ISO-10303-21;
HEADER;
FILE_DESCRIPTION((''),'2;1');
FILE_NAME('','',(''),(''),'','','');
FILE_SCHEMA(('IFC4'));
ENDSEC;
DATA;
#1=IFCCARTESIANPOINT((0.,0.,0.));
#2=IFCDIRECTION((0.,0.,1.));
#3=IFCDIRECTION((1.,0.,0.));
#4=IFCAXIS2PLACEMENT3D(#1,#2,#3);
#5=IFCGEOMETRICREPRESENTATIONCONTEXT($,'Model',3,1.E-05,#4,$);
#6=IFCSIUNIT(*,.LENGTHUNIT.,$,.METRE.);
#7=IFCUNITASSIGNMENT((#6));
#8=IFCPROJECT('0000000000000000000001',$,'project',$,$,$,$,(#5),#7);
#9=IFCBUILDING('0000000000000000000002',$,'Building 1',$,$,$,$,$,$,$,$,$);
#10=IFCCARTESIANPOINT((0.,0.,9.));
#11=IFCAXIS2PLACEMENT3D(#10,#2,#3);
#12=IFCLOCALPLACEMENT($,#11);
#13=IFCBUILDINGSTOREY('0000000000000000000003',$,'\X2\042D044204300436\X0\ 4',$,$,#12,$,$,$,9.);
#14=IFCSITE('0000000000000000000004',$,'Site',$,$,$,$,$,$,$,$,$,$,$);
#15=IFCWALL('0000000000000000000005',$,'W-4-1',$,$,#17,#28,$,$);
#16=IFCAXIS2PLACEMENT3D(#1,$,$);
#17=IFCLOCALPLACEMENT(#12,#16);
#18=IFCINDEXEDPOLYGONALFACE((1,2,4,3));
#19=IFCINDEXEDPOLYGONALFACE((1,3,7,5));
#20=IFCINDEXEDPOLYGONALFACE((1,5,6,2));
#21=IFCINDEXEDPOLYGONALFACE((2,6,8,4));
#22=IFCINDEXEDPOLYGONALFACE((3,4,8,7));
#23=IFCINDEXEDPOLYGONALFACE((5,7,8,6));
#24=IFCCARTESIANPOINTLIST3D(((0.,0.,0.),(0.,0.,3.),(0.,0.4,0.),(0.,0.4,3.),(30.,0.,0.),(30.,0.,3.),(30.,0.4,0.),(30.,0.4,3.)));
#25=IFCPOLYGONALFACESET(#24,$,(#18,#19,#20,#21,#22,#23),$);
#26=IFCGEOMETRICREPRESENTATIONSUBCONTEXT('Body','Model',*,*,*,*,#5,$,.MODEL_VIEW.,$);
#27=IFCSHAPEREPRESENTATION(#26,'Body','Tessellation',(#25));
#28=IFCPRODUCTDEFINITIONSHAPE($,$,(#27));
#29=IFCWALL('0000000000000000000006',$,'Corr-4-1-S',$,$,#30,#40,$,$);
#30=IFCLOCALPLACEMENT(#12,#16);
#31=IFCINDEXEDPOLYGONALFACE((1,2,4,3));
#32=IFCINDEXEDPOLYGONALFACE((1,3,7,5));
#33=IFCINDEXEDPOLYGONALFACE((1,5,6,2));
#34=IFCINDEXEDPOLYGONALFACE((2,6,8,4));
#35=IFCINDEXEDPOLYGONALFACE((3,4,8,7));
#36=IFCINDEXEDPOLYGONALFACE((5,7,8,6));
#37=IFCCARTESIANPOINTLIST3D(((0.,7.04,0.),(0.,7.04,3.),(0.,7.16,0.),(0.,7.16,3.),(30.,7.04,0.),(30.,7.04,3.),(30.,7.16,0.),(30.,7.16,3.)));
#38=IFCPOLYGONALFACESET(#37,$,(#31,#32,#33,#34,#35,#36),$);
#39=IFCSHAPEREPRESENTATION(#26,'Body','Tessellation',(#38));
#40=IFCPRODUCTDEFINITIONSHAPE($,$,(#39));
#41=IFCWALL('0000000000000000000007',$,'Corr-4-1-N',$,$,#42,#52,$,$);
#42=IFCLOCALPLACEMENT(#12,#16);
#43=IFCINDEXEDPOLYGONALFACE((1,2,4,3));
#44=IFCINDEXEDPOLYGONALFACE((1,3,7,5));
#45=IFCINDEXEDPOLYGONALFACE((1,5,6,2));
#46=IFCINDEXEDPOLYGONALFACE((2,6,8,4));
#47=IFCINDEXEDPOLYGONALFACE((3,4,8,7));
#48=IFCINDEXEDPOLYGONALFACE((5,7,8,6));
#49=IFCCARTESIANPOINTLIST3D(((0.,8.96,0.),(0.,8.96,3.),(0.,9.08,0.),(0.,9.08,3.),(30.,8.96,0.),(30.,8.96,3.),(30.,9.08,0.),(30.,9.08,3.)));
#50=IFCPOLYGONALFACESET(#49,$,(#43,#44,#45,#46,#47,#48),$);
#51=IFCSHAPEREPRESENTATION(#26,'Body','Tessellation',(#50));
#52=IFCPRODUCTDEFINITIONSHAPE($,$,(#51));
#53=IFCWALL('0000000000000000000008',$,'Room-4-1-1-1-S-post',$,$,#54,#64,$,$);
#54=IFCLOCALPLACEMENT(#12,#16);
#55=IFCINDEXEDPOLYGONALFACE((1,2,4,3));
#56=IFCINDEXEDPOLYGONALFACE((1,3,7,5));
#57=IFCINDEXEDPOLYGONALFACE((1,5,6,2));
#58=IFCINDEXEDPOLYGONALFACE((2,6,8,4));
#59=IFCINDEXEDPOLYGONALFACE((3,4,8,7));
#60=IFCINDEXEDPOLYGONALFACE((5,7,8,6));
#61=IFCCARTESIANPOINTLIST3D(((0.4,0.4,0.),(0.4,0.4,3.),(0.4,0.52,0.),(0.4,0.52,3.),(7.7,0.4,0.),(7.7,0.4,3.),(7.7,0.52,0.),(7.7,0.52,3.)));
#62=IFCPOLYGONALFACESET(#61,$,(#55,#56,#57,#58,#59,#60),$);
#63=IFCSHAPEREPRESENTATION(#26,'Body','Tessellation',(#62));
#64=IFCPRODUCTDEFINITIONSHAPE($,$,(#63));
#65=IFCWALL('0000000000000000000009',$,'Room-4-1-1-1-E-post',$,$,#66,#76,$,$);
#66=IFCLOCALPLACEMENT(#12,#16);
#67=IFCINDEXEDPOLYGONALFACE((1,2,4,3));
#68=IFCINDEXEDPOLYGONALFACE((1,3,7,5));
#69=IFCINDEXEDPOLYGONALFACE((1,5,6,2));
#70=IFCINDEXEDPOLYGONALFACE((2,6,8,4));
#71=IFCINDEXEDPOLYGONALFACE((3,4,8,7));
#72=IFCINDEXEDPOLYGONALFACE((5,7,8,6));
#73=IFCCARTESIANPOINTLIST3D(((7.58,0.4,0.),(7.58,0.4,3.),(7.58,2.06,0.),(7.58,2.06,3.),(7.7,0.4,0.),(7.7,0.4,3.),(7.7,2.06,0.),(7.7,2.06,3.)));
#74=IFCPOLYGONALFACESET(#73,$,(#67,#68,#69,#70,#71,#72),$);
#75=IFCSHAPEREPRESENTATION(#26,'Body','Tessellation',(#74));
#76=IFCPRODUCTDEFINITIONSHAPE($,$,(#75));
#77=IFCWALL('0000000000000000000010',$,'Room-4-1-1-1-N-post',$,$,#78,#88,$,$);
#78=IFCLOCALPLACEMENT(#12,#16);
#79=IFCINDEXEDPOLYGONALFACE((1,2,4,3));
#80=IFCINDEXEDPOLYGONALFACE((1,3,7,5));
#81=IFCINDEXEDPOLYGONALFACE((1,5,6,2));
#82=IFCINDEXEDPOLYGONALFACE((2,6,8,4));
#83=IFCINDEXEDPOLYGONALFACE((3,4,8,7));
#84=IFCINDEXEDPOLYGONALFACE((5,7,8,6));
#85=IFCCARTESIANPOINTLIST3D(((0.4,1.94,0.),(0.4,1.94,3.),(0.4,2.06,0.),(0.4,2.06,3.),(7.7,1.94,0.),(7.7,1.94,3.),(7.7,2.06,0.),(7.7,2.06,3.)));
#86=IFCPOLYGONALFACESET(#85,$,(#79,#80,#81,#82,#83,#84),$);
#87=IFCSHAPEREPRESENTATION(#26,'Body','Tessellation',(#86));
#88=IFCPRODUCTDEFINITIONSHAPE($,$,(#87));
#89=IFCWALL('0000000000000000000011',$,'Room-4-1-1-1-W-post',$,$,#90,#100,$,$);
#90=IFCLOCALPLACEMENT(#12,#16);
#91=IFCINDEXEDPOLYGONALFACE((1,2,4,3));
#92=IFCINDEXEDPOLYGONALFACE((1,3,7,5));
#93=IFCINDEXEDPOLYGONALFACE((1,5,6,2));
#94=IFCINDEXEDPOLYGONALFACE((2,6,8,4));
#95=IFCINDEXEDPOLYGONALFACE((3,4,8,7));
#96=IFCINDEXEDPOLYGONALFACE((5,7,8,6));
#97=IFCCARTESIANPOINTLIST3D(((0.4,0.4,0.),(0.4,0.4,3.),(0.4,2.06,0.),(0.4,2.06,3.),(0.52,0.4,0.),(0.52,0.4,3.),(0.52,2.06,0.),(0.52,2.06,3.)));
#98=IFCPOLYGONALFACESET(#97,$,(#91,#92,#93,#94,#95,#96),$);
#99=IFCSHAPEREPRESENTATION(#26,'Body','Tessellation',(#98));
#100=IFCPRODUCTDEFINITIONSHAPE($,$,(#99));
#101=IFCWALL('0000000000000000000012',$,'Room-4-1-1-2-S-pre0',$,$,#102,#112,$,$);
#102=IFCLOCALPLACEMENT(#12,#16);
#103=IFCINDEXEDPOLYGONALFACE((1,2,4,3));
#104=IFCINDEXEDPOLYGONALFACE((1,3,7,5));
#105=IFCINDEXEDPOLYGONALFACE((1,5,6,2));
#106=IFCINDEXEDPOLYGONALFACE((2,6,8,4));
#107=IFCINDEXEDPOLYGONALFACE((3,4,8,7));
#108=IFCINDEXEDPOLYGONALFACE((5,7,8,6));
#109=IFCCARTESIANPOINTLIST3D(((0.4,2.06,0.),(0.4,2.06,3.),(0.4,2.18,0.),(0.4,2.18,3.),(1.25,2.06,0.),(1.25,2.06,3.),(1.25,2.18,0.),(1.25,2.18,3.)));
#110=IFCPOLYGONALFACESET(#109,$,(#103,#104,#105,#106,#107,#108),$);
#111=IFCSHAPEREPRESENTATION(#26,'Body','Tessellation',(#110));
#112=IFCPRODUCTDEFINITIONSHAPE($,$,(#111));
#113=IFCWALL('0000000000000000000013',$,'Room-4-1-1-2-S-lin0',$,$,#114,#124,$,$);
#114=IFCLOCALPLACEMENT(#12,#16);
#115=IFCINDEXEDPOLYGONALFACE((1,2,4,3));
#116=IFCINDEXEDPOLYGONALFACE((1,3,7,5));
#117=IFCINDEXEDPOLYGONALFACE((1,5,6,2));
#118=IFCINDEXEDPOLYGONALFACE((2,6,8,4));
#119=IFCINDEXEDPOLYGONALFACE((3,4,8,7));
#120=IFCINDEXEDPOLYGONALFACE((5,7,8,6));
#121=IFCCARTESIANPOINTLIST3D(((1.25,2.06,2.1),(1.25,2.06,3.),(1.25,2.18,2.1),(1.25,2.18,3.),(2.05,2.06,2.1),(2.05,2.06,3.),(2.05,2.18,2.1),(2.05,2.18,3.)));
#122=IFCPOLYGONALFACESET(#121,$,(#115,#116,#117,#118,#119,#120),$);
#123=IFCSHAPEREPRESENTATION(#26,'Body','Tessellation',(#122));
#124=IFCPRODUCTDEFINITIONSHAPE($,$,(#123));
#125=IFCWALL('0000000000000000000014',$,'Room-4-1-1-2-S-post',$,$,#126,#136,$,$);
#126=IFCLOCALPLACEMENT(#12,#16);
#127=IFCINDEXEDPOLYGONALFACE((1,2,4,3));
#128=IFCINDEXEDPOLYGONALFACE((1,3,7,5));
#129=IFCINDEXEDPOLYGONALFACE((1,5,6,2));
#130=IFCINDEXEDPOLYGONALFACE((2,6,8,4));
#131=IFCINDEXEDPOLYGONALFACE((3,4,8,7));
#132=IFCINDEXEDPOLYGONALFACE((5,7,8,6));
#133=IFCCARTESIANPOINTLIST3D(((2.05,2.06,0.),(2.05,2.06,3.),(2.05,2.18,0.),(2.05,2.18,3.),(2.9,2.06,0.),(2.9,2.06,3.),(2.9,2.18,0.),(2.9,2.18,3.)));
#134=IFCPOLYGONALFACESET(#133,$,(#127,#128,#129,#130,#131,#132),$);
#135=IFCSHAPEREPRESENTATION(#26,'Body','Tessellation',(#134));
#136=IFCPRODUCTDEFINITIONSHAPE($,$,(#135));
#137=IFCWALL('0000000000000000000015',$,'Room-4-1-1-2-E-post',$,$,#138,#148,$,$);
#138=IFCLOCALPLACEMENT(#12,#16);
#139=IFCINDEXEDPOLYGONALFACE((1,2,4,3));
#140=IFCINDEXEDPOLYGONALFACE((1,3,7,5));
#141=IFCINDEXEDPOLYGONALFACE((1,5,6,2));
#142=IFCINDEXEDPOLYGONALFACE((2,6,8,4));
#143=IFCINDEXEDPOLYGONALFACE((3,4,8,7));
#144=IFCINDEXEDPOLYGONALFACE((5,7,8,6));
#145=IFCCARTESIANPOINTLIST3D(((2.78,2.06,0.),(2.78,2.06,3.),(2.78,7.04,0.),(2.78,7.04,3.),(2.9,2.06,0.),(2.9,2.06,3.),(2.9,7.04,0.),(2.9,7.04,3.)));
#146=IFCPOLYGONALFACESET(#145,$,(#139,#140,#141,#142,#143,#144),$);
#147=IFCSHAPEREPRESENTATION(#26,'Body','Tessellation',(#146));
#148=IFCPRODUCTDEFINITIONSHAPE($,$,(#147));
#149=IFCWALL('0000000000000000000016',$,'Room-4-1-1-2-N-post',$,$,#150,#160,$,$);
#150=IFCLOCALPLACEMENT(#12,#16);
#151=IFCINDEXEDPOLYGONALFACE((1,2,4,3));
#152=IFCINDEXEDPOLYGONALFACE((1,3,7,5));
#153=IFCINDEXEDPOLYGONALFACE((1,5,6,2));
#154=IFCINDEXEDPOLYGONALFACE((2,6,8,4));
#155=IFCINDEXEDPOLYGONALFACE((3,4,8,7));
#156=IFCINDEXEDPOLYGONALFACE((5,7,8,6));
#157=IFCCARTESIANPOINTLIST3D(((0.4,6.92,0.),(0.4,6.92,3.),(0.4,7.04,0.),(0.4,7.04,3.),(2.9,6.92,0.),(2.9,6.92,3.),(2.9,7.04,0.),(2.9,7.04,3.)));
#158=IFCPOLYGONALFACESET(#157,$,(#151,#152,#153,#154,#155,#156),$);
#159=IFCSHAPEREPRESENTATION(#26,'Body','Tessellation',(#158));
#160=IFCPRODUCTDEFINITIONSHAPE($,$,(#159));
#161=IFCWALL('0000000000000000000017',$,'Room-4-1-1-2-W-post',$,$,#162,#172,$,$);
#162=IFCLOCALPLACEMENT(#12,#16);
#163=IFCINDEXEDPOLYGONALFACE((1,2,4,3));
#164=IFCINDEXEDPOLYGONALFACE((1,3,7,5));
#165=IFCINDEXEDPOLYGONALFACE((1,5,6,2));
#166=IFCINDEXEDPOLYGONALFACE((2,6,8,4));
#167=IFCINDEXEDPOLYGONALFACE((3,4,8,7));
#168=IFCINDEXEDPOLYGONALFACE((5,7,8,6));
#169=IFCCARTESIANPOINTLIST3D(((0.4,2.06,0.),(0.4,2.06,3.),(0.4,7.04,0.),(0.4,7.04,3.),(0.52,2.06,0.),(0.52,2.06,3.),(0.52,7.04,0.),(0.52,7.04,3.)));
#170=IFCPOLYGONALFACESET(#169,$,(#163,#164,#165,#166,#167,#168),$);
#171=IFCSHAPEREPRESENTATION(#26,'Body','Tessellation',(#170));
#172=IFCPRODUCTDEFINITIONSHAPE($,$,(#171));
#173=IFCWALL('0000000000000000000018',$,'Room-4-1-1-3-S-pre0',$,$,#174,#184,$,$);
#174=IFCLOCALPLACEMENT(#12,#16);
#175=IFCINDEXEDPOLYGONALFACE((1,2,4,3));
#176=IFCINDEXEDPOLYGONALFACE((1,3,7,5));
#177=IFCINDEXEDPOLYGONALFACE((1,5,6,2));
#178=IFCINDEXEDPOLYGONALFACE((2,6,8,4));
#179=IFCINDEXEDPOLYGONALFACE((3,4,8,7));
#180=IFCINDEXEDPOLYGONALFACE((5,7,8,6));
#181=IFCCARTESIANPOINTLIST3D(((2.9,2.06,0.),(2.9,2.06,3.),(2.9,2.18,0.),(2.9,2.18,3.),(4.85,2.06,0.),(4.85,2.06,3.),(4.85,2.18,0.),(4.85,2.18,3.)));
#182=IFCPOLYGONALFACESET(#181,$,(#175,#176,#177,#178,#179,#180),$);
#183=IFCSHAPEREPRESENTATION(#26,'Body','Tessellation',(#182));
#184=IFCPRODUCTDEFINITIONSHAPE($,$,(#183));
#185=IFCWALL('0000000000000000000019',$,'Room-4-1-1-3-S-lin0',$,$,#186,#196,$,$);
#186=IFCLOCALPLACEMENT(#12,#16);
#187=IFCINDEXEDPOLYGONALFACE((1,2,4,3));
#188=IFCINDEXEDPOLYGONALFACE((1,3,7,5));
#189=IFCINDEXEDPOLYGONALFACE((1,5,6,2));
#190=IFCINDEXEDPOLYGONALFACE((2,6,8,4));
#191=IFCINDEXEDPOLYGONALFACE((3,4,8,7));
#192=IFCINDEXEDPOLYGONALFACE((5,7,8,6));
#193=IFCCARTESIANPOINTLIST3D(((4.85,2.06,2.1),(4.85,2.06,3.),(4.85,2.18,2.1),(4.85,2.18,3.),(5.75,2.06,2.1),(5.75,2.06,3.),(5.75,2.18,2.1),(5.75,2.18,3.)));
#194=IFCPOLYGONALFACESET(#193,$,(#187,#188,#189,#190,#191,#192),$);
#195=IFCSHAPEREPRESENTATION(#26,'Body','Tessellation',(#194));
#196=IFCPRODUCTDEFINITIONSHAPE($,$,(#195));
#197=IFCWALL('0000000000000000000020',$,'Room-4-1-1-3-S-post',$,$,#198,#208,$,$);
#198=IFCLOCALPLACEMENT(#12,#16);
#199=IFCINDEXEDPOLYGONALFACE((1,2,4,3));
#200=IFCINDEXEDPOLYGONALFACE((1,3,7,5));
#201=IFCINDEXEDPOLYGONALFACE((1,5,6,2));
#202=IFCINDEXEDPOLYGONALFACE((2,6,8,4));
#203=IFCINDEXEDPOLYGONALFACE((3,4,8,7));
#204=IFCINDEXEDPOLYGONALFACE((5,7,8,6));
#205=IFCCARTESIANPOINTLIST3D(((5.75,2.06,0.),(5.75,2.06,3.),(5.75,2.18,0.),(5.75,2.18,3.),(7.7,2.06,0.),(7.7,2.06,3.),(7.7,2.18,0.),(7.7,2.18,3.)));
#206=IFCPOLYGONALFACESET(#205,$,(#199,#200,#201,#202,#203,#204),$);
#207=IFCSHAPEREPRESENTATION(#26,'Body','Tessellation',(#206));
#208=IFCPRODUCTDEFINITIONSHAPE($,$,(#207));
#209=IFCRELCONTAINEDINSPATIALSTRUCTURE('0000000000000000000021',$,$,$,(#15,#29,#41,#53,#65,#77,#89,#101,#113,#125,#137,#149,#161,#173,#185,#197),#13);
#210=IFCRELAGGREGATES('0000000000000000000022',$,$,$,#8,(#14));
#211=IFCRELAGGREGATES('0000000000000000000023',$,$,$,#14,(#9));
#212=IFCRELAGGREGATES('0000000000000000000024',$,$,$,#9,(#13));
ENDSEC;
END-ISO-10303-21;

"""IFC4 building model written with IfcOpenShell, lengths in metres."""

from ifc_helpers import new_model, si_unit, frame, origin_with_axes, place, context, subcontext, project, spatial, indexed_curve, outline, extrude, element, save


model = new_model("IFC4")

# Units and contexts
model_context = context("Model", 3, precision=1e-05, world=origin_with_axes())
body_context = subcontext(model_context, "Body", "Model", "MODEL_VIEW")
ifc_project = project(units=[si_unit("LENGTHUNIT", "METRE")], contexts=[model_context])

# Site, building, storey
site = spatial("IfcSite", under=ifc_project, Name="Site")
building = spatial("IfcBuilding", under=site, Name="Building 1")
storey_placement = place(None, frame((0.0, 0.0, 9.0), z_axis=(0.0, 0.0, 1.0), x_axis=(1.0, 0.0, 0.0)))
storey = spatial("IfcBuildingStorey", under=building, at=storey_placement, Name="Этаж 4", Elevation=9.0)

# Walls
wall_1_placement = place(storey_placement, origin_with_axes())
element("IfcWall", 1, at=wall_1_placement, inside=storey, Name="W-4-1", context=body_context, shape_type="SweptSolid", body=[
    extrude(outline(indexed_curve([(0.0, 0.0), (0.0, 0.4), (30.0, 0.4), (30.0, 0.0), (0.0, 0.0)], self_intersect=False)), origin_with_axes(), (0.0, 0.0, 1.0), 3.0),
])
for number, where, z_axis, x_axis, name in (
    (2, (0.0, 7.04, 0.0), (0.0, 0.0, 1.0), (1.0, 0.0, 0.0), "Corr-4-1-S"),
    (3, (0.0, 8.96, 0.0), (0.0, 0.0, 1.0), (1.0, 0.0, 0.0), "Corr-4-1-N"),
):
    element("IfcWall", number, at=place(storey_placement, frame(where, z_axis=z_axis, x_axis=x_axis)), inside=storey, Name=name, context=body_context, shape_type="SweptSolid", body=[
        extrude(outline(indexed_curve([(0.0, 0.0), (0.0, 0.12), (30.0, 0.12), (30.0, 0.0), (0.0, 0.0)], self_intersect=False)), origin_with_axes(), (0.0, 0.0, 1.0), 3.0),
    ])
wall_2_placement = place(storey_placement, frame((0.4, 0.4, 0.0), z_axis=(0.0, 0.0, 1.0), x_axis=(1.0, 0.0, 0.0)))
element("IfcWall", 4, at=wall_2_placement, inside=storey, Name="Room-4-1-1-1-S-post", context=body_context, shape_type="SweptSolid", body=[
    extrude(outline(indexed_curve([(0.0, 0.0), (0.0, 0.12), (7.3, 0.12), (7.3, 0.0), (0.0, 0.0)], self_intersect=False)), origin_with_axes(), (0.0, 0.0, 1.0), 3.0),
])
wall_3_placement = place(storey_placement, frame((7.7, 0.4, 0.0), z_axis=(0.0, 0.0, 1.0), x_axis=(0.0, 1.0, 0.0)))
element("IfcWall", 5, at=wall_3_placement, inside=storey, Name="Room-4-1-1-1-E-post", context=body_context, shape_type="SweptSolid", body=[
    extrude(outline(indexed_curve([(0.0, 0.0), (0.0, 0.12), (1.66, 0.12), (1.66, 0.0), (0.0, 0.0)], self_intersect=False)), origin_with_axes(), (0.0, 0.0, 1.0), 3.0),
])
wall_4_placement = place(storey_placement, frame((7.7, 2.06, 0.0), z_axis=(0.0, 0.0, 1.0), x_axis=(-1.0, 0.0, 0.0)))
element("IfcWall", 6, at=wall_4_placement, inside=storey, Name="Room-4-1-1-1-N-post", context=body_context, shape_type="SweptSolid", body=[
    extrude(outline(indexed_curve([(0.0, 0.0), (0.0, 0.12), (7.3, 0.12), (7.3, 0.0), (0.0, 0.0)], self_intersect=False)), origin_with_axes(), (0.0, 0.0, 1.0), 3.0),
])
wall_5_placement = place(storey_placement, frame((0.4, 2.06, 0.0), z_axis=(0.0, 0.0, 1.0), x_axis=(0.0, -1.0, 0.0)))
element("IfcWall", 7, at=wall_5_placement, inside=storey, Name="Room-4-1-1-1-W-post", context=body_context, shape_type="SweptSolid", body=[
    extrude(outline(indexed_curve([(0.0, 0.0), (0.0, 0.12), (1.66, 0.12), (1.66, 0.0), (0.0, 0.0)], self_intersect=False)), origin_with_axes(), (0.0, 0.0, 1.0), 3.0),
])
wall_6_placement = place(storey_placement, frame((0.4, 2.06, 0.0), z_axis=(0.0, 0.0, 1.0), x_axis=(1.0, 0.0, 0.0)))
element("IfcWall", 8, at=wall_6_placement, inside=storey, Name="Room-4-1-1-2-S-pre0", context=body_context, shape_type="SweptSolid", body=[
    extrude(outline(indexed_curve([(0.0, 0.0), (0.0, 0.12), (0.85, 0.12), (0.85, 0.0), (0.0, 0.0)], self_intersect=False)), origin_with_axes(), (0.0, 0.0, 1.0), 3.0),
])
wall_7_placement = place(storey_placement, frame((1.25, 2.06, 2.1), z_axis=(0.0, 0.0, 1.0), x_axis=(1.0, 0.0, 0.0)))
element("IfcWall", 9, at=wall_7_placement, inside=storey, Name="Room-4-1-1-2-S-lin0", context=body_context, shape_type="SweptSolid", body=[
    extrude(outline(indexed_curve([(0.0, 0.0), (0.0, 0.12), (0.8, 0.12), (0.8, 0.0), (0.0, 0.0)], self_intersect=False)), origin_with_axes(), (0.0, 0.0, 1.0), 0.9),
])
wall_8_placement = place(storey_placement, frame((2.05, 2.06, 0.0), z_axis=(0.0, 0.0, 1.0), x_axis=(1.0, 0.0, 0.0)))
element("IfcWall", 10, at=wall_8_placement, inside=storey, Name="Room-4-1-1-2-S-post", context=body_context, shape_type="SweptSolid", body=[
    extrude(outline(indexed_curve([(0.0, 0.0), (0.0, 0.12), (0.85, 0.12), (0.85, 0.0), (0.0, 0.0)], self_intersect=False)), origin_with_axes(), (0.0, 0.0, 1.0), 3.0),
])
wall_9_placement = place(storey_placement, frame((2.9, 2.06, 0.0), z_axis=(0.0, 0.0, 1.0), x_axis=(0.0, 1.0, 0.0)))
element("IfcWall", 11, at=wall_9_placement, inside=storey, Name="Room-4-1-1-2-E-post", context=body_context, shape_type="SweptSolid", body=[
    extrude(outline(indexed_curve([(0.0, 0.0), (0.0, 0.12), (4.98, 0.12), (4.98, 0.0), (0.0, 0.0)], self_intersect=False)), origin_with_axes(), (0.0, 0.0, 1.0), 3.0),
])
wall_10_placement = place(storey_placement, frame((2.9, 7.04, 0.0), z_axis=(0.0, 0.0, 1.0), x_axis=(-1.0, 0.0, 0.0)))
element("IfcWall", 12, at=wall_10_placement, inside=storey, Name="Room-4-1-1-2-N-post", context=body_context, shape_type="SweptSolid", body=[
    extrude(outline(indexed_curve([(0.0, 0.0), (0.0, 0.12), (2.5, 0.12), (2.5, 0.0), (0.0, 0.0)], self_intersect=False)), origin_with_axes(), (0.0, 0.0, 1.0), 3.0),
])
wall_11_placement = place(storey_placement, frame((0.4, 7.04, 0.0), z_axis=(0.0, 0.0, 1.0), x_axis=(0.0, -1.0, 0.0)))
element("IfcWall", 13, at=wall_11_placement, inside=storey, Name="Room-4-1-1-2-W-post", context=body_context, shape_type="SweptSolid", body=[
    extrude(outline(indexed_curve([(0.0, 0.0), (0.0, 0.12), (4.98, 0.12), (4.98, 0.0), (0.0, 0.0)], self_intersect=False)), origin_with_axes(), (0.0, 0.0, 1.0), 3.0),
])
wall_12_placement = place(storey_placement, frame((2.9, 2.06, 0.0), z_axis=(0.0, 0.0, 1.0), x_axis=(1.0, 0.0, 0.0)))
element("IfcWall", 14, at=wall_12_placement, inside=storey, Name="Room-4-1-1-3-S-pre0", context=body_context, shape_type="SweptSolid", body=[
    extrude(outline(indexed_curve([(0.0, 0.0), (0.0, 0.12), (1.95, 0.12), (1.95, 0.0), (0.0, 0.0)], self_intersect=False)), origin_with_axes(), (0.0, 0.0, 1.0), 3.0),
])
wall_13_placement = place(storey_placement, frame((4.85, 2.06, 2.1), z_axis=(0.0, 0.0, 1.0), x_axis=(1.0, 0.0, 0.0)))
element("IfcWall", 15, at=wall_13_placement, inside=storey, Name="Room-4-1-1-3-S-lin0", context=body_context, shape_type="SweptSolid", body=[
    extrude(outline(indexed_curve([(0.0, 0.0), (0.0, 0.12), (0.9, 0.12), (0.9, 0.0), (0.0, 0.0)], self_intersect=False)), origin_with_axes(), (0.0, 0.0, 1.0), 0.9),
])
wall_14_placement = place(storey_placement, frame((5.75, 2.06, 0.0), z_axis=(0.0, 0.0, 1.0), x_axis=(1.0, 0.0, 0.0)))
element("IfcWall", 16, at=wall_14_placement, inside=storey, Name="Room-4-1-1-3-S-post", context=body_context, shape_type="SweptSolid", body=[
    extrude(outline(indexed_curve([(0.0, 0.0), (0.0, 0.12), (1.95, 0.12), (1.95, 0.0), (0.0, 0.0)], self_intersect=False)), origin_with_axes(), (0.0, 0.0, 1.0), 3.0),
])

save(model, "model.ifc")
